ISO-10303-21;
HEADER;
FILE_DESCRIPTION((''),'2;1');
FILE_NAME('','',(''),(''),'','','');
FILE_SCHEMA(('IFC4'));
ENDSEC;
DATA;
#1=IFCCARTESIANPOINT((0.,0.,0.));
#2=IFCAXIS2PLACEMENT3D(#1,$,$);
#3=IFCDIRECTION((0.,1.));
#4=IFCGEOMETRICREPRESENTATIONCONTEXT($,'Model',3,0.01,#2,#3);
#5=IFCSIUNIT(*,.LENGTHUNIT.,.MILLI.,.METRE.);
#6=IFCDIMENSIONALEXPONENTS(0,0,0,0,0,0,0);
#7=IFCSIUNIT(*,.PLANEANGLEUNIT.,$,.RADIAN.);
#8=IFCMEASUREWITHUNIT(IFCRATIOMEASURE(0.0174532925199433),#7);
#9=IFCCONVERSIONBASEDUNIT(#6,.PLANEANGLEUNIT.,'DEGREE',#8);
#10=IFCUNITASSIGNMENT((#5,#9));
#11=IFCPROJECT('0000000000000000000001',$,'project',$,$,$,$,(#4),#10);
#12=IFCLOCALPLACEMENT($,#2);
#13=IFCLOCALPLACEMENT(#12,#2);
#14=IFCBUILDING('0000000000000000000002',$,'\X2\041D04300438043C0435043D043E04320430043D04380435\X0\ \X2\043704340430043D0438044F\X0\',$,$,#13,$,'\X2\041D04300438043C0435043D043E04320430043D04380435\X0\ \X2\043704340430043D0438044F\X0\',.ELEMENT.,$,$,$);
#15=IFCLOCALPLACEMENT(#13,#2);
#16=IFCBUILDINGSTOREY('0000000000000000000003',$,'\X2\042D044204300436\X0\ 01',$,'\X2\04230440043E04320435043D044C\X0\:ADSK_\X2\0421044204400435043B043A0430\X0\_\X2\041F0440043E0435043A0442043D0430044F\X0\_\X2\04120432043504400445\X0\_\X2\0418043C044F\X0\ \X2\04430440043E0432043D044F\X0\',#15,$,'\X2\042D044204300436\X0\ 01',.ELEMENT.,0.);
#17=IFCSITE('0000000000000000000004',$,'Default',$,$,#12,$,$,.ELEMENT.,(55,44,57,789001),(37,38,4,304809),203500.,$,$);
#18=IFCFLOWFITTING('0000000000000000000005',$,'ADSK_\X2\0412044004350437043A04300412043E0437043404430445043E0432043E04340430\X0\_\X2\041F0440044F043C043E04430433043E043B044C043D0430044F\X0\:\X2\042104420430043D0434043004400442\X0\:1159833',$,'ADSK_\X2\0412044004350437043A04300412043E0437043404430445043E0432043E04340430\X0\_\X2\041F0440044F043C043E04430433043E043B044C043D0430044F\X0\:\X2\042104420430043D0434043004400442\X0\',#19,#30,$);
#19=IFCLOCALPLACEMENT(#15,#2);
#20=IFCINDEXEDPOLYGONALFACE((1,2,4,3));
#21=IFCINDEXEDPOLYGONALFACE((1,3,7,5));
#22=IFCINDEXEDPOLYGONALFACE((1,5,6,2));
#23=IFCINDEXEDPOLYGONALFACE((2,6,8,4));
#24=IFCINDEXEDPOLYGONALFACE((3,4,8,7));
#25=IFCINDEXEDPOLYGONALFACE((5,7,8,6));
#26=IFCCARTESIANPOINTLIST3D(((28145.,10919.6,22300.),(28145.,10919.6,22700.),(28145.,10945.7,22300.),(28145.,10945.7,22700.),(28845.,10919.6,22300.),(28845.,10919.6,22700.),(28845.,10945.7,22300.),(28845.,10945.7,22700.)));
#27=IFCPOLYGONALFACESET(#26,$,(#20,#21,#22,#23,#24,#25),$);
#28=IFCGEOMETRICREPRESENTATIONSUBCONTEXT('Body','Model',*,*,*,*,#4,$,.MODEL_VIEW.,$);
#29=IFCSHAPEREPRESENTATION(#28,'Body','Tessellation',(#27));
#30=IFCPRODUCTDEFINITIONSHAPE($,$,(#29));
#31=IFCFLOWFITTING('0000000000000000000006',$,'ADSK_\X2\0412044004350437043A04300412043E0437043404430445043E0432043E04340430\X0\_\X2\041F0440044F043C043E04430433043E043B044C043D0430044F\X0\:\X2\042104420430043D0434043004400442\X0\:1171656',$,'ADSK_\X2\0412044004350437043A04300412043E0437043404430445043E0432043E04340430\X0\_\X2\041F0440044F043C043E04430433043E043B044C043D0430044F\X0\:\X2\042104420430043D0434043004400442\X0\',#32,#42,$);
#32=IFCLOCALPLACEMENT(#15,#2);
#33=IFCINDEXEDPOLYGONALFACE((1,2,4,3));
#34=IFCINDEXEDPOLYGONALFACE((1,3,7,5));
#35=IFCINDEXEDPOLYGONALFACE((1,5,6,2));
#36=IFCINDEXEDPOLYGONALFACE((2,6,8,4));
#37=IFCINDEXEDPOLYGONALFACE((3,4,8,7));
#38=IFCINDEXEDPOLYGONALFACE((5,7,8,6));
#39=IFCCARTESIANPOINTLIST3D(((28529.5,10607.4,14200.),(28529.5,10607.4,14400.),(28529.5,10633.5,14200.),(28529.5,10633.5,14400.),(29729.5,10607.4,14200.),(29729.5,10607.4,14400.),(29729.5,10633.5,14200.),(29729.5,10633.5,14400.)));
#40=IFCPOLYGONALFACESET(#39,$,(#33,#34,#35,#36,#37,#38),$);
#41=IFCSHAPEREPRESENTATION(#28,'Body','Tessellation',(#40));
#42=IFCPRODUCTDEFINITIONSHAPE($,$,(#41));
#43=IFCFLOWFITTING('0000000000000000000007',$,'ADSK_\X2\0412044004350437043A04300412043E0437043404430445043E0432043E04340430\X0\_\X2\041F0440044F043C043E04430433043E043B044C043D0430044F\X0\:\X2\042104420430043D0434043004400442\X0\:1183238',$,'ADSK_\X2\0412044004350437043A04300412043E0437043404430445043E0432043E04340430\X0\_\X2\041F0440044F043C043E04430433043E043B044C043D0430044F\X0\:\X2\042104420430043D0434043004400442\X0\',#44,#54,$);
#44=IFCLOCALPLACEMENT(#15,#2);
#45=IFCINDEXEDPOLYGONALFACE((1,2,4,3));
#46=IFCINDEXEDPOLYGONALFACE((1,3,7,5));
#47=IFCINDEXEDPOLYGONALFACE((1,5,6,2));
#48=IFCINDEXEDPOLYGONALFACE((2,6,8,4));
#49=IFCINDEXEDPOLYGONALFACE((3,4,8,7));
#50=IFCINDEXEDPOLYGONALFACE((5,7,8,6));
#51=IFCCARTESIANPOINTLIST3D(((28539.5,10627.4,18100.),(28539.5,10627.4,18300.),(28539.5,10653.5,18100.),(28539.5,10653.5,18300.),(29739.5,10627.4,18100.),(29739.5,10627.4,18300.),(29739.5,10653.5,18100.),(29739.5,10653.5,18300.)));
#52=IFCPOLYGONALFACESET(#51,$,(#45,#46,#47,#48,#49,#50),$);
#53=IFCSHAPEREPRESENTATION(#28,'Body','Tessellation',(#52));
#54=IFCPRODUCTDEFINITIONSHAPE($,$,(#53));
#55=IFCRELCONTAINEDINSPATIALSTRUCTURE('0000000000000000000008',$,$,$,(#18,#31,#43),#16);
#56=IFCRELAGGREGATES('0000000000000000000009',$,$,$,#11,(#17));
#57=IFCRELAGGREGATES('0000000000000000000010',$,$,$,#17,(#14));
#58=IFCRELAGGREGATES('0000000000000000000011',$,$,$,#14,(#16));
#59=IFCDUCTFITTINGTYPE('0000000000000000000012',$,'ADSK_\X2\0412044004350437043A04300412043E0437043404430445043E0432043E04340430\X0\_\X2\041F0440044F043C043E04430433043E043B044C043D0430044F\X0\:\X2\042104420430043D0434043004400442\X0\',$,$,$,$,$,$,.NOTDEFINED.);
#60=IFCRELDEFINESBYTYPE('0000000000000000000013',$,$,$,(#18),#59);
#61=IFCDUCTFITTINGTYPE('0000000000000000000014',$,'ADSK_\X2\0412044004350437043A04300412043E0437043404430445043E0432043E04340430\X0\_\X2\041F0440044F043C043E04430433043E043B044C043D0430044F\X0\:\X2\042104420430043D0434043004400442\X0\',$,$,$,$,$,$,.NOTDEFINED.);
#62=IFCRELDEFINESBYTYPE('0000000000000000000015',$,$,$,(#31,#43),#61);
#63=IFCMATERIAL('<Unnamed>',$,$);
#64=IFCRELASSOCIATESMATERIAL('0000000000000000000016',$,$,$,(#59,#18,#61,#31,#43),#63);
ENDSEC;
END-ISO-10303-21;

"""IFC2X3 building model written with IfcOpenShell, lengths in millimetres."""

from ifc_helpers import new_model, entity, si_unit, converted_unit, direction, frame, frame_2d, origin, place, context, subcontext, project, spatial, rectangle, extrude, source, transform, mapped, material, type_object, type_shapes, element, save


model = new_model("IFC2X3")

# Units and contexts
model_context = context("Model", 3, precision=0.01, world=origin(), true_north=direction((0.0, 1.0)))
body_context = subcontext(model_context, "Body", "Model", "MODEL_VIEW")
ifc_project = project(units=[si_unit("LENGTHUNIT", "METRE", prefix="MILLI"), converted_unit("PLANEANGLEUNIT", "DEGREE", entity("IfcRatioMeasure", 0.0174532925199433), si_unit("PLANEANGLEUNIT", "RADIAN"), dimensions=[0, 0, 0, 0, 0, 0, 0])], contexts=[model_context])

# Site, building, storey
site_placement = place(None, frame((0.0, 0.0, 0.0)))
site = spatial("IfcSite", under=ifc_project, at=site_placement, Name="Default", CompositionType="ELEMENT", RefLatitude=(55, 44, 57, 789001), RefLongitude=(37, 38, 4, 304809), RefElevation=203500.0)
building_placement = place(site_placement, origin())
building = spatial("IfcBuilding", under=site, at=building_placement, Name="Наименование здания", LongName="Наименование здания", CompositionType="ELEMENT")
storey_placement = place(building_placement, origin())
storey = spatial("IfcBuildingStorey", under=building, at=storey_placement, Name="Этаж 01", ObjectType="Уровень:ADSK_Стрелка_Проектная_Вверх_Имя уровня", LongName="Этаж 01", CompositionType="ELEMENT", Elevation=0.0)

# Shared definitions
ifc_material_1 = material(Name="<Unnamed>")

# Flow fittings
duct_fitting_type_1 = type_object("IfcDuctFittingType", Name="ADSK_ВрезкаВоздуховода_Прямоугольная:Стандарт", PredefinedType="NOTDEFINED", material=ifc_material_1)
shared_shape_1 = source(origin(), body_context, "Body", "SweptSolid", [
    extrude(rectangle(XDim=700.0, YDim=26.1, at=frame_2d((0.0, 0.0), x_axis=(1.0, 0.0))), frame((7.0, 0.0, -200.0), z_axis=(0.0, 0.0, 1.0), x_axis=(0.0, -1.0, 0.0)), (0.0, 0.0, 1.0), 400.0),
])
type_shapes(duct_fitting_type_1, [shared_shape_1])
flow_fitting_1_placement = place(storey_placement, frame((28495.0, 10939.6, 22500.0), z_axis=(0.0, 0.0, -1.0), x_axis=(0.0, -1.0, 0.0)))
element("IfcFlowFitting", 1, at=flow_fitting_1_placement, inside=storey, type_object=duct_fitting_type_1, material=ifc_material_1, Name="ADSK_ВрезкаВоздуховода_Прямоугольная:Стандарт:1159833", ObjectType="ADSK_ВрезкаВоздуховода_Прямоугольная:Стандарт", context=body_context, shape_type="MappedRepresentation", body=[
    mapped(shared_shape_1, transform((0.0, 0.0, 0.0), scale=1.0)),
])
duct_fitting_type_2 = type_object("IfcDuctFittingType", Name="ADSK_ВрезкаВоздуховода_Прямоугольная:Стандарт", PredefinedType="NOTDEFINED", material=ifc_material_1)
shared_shape_2 = source(origin(), body_context, "Body", "SweptSolid", [
    extrude(rectangle(XDim=26.1, YDim=1200.0, at=frame_2d((0.0, 0.0), x_axis=(1.0, 0.0))), frame((7.0, 0.0, -100.0)), (0.0, 0.0, 1.0), 200.0),
])
type_shapes(duct_fitting_type_2, [shared_shape_2])
for number, where, z_axis, x_axis, name in (
    (2, (29129.5, 10627.4, 14300.0), (0.0, 0.0, -1.0), (0.0, -1.0, 0.0), "ADSK_ВрезкаВоздуховода_Прямоугольная:Стандарт:1171656"),
    (3, (29139.5, 10647.4, 18200.0), (0.0, 0.0, 1.0), (0.0, -1.0, 0.0), "ADSK_ВрезкаВоздуховода_Прямоугольная:Стандарт:1183238"),
):
    element("IfcFlowFitting", number, at=place(storey_placement, frame(where, z_axis=z_axis, x_axis=x_axis)), inside=storey, type_object=duct_fitting_type_2, material=ifc_material_1, Name=name, ObjectType="ADSK_ВрезкаВоздуховода_Прямоугольная:Стандарт", context=body_context, shape_type="MappedRepresentation", body=[
        mapped(shared_shape_2, transform((0.0, 0.0, 0.0), scale=1.0)),
    ])

save(model, "model.ifc")
